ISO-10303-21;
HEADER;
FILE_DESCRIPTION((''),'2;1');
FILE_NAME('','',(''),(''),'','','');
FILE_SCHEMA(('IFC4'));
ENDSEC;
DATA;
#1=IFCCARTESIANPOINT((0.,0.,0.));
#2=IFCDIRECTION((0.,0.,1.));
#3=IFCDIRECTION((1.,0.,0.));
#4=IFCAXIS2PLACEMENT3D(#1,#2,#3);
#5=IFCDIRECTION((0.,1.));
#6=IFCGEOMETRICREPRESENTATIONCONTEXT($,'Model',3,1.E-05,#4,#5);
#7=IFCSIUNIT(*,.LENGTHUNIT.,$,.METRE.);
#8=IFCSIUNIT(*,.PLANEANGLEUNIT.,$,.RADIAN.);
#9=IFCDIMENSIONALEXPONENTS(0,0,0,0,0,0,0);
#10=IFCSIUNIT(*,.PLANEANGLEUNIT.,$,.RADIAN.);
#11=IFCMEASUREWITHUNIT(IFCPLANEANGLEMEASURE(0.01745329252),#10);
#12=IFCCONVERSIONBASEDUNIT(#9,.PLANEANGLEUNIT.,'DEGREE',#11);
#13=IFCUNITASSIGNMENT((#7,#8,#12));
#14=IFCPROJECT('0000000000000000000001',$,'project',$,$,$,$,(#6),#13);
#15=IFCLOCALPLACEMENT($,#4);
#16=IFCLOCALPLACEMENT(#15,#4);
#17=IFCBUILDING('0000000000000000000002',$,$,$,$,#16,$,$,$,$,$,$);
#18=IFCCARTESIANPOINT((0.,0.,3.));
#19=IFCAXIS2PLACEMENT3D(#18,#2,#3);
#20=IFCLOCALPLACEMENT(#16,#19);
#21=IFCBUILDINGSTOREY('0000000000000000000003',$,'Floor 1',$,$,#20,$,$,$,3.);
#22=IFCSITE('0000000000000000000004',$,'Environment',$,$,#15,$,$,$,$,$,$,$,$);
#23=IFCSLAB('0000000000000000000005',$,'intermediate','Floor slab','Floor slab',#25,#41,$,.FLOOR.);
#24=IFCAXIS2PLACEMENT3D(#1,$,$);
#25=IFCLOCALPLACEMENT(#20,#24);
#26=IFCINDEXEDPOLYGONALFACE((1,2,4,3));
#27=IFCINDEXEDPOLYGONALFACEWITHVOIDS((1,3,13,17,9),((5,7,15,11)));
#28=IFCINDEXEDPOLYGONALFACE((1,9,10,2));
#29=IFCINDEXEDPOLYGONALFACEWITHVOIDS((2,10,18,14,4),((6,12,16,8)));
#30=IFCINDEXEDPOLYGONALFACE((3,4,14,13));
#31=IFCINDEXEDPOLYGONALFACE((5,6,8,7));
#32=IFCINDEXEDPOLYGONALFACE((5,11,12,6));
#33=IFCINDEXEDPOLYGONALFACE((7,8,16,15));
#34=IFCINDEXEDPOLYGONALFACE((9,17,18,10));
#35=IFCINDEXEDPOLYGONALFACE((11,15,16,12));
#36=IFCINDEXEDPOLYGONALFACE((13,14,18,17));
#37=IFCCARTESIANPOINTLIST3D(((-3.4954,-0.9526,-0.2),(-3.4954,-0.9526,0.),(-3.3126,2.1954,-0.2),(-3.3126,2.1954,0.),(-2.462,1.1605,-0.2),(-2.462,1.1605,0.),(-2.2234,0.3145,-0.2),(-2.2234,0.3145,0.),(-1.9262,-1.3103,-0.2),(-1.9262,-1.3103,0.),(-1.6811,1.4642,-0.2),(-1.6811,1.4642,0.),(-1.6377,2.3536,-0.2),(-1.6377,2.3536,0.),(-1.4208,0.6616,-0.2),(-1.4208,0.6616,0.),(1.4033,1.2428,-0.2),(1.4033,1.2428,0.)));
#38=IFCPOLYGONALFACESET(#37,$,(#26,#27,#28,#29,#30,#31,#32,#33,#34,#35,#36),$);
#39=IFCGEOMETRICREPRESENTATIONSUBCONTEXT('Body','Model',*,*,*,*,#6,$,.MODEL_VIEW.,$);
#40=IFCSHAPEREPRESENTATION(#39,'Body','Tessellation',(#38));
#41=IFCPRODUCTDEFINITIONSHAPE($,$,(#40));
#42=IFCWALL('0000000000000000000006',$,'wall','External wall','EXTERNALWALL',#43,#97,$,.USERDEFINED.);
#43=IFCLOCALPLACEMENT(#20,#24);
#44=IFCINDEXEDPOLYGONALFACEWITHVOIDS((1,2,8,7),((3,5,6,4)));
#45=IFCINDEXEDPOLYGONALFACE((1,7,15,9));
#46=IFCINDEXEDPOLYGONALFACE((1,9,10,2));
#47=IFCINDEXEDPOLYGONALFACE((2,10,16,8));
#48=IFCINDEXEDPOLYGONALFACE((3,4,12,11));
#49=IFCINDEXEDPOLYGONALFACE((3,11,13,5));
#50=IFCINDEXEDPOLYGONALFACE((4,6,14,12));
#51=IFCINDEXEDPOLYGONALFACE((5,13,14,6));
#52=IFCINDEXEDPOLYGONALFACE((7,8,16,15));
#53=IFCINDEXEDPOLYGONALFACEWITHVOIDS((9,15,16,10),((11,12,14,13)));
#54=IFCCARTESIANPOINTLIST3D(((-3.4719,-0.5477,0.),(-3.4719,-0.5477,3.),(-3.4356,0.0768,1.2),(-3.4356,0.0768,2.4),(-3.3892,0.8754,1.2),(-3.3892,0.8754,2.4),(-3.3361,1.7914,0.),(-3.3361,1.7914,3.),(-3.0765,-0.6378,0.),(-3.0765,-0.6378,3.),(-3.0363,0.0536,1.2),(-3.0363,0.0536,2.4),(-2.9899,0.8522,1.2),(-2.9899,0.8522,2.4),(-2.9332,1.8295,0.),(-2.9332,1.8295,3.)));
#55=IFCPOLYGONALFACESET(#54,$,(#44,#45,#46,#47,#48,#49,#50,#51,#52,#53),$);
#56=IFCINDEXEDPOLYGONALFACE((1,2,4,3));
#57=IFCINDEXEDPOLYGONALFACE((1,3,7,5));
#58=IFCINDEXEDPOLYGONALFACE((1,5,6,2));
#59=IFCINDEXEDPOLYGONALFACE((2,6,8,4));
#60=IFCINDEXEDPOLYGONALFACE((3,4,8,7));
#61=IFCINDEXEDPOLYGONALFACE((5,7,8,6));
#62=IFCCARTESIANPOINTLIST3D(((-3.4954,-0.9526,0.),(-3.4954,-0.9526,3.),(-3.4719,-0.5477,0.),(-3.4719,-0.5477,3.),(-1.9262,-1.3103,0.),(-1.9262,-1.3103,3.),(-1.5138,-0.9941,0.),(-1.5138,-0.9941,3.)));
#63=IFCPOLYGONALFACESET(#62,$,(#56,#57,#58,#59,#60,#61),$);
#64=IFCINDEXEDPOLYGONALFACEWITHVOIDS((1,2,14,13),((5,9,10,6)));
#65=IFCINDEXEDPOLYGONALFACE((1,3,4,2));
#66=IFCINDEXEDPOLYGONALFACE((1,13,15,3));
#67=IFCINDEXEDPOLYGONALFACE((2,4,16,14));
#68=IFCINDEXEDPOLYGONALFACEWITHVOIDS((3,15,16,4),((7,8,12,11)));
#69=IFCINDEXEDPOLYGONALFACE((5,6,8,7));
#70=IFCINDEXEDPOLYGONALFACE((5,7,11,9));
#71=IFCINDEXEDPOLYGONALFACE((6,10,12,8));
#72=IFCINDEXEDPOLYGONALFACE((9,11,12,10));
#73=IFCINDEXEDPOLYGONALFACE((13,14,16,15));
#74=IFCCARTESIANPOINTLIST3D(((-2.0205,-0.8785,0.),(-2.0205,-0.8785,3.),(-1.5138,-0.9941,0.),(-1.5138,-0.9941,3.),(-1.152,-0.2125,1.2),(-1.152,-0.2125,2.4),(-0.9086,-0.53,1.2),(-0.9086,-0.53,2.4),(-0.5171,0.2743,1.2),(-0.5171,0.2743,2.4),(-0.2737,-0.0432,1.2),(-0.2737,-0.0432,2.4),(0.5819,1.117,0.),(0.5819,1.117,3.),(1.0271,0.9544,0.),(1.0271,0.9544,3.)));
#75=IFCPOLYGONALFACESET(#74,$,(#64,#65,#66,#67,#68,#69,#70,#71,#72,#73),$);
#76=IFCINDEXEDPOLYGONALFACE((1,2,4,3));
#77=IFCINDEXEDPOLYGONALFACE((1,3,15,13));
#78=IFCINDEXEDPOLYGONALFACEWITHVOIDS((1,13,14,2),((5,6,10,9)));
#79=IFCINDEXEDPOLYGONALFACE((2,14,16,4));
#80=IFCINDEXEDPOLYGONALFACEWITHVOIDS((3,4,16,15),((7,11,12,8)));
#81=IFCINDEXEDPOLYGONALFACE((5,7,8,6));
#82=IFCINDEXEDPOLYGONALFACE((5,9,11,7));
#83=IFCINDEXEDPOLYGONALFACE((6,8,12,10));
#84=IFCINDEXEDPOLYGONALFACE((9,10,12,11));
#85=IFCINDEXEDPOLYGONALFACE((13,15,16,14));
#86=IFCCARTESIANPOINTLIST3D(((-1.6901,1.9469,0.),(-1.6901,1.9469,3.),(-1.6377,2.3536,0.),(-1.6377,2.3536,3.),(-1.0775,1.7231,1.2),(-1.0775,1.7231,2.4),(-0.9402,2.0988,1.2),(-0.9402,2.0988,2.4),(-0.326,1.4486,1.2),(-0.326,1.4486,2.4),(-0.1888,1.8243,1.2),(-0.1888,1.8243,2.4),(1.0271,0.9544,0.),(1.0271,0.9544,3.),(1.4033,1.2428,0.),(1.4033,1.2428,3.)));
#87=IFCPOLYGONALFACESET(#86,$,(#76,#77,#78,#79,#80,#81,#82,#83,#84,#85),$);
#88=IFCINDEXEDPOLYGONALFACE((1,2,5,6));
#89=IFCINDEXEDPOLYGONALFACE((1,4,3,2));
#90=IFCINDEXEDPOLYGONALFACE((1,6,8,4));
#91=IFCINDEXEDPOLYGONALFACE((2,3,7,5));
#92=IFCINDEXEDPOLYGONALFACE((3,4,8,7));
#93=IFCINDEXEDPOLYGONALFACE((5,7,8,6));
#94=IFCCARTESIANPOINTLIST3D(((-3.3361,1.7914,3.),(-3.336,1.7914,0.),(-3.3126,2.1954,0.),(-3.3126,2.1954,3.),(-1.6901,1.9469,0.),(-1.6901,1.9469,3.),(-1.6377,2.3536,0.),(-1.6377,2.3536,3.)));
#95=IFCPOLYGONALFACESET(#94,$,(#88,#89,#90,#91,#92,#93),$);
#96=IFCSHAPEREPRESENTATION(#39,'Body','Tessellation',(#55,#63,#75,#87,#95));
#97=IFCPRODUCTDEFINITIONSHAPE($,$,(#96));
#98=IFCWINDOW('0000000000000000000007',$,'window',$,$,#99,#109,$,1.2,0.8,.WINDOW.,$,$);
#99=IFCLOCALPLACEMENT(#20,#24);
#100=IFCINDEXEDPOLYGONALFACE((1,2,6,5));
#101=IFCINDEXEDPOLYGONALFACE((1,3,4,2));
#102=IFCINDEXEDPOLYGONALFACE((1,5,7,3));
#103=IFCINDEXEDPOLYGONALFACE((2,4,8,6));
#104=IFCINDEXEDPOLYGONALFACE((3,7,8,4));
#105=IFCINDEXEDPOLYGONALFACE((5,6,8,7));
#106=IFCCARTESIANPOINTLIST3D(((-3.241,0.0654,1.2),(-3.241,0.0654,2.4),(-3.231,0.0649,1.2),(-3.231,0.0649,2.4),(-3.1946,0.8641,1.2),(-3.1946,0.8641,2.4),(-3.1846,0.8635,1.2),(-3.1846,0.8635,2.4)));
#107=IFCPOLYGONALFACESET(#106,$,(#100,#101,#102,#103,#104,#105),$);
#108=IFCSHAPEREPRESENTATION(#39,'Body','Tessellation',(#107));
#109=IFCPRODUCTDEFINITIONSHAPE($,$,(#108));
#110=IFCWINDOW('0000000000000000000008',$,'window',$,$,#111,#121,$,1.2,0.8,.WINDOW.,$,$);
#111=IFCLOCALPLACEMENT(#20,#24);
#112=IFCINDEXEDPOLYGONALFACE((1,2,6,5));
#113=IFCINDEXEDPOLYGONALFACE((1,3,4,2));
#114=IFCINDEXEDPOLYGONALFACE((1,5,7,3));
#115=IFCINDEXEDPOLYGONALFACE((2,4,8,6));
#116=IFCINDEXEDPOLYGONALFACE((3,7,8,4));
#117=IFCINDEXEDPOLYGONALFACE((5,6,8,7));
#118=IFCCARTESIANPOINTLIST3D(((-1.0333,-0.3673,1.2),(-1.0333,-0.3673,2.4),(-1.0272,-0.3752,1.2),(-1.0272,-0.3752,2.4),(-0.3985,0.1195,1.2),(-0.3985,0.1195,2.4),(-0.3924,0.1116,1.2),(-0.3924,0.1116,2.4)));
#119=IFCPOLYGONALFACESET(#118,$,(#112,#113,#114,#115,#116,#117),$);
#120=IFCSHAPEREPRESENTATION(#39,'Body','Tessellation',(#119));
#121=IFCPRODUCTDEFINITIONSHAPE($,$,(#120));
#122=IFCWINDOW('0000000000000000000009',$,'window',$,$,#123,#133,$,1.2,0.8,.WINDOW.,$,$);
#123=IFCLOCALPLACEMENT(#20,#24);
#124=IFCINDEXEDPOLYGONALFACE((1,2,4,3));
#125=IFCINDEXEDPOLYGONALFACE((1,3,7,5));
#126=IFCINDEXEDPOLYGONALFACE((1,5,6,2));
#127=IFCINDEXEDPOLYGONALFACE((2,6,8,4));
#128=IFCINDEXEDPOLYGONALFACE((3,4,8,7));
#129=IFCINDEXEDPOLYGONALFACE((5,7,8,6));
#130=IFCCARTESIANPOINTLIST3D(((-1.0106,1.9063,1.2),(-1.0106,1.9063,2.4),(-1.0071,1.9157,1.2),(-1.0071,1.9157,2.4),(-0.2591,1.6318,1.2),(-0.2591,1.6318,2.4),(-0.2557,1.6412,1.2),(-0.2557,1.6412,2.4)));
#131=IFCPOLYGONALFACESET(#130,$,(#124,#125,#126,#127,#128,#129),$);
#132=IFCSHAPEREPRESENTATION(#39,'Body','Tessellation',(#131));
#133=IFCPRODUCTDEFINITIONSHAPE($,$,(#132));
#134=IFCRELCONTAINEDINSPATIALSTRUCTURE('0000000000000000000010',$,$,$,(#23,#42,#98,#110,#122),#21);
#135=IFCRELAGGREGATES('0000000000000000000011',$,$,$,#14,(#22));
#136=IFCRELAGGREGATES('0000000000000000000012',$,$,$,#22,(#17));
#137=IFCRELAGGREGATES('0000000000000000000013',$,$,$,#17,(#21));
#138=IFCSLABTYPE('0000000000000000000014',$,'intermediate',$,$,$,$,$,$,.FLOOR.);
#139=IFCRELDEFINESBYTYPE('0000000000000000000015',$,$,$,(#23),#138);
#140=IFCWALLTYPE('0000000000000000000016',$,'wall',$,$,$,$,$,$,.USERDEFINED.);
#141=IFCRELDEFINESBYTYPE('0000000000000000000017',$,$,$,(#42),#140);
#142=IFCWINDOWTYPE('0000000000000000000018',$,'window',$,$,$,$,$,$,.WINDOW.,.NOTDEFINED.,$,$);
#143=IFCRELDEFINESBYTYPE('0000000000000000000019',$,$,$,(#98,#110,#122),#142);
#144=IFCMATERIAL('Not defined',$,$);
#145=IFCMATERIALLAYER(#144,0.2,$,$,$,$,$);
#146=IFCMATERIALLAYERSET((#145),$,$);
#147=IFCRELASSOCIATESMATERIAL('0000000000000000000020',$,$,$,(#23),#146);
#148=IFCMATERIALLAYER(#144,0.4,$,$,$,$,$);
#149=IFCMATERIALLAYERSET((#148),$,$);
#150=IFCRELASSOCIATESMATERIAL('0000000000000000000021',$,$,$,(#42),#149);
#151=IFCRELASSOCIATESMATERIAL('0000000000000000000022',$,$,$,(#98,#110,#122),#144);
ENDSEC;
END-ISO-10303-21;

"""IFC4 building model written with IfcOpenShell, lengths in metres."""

from ifc_helpers import new_model, entity, si_unit, converted_unit, direction, frame, origin_with_axes, origin_2d_with_axis, place, context, subcontext, project, spatial, polyline, rectangle, outline, extrude, shape, material, layer, layer_set, layer_usage, type_object, element, fill, save


model = new_model("IFC4")

# Units and contexts
model_context = context("Model", 3, precision=1e-05, world=origin_with_axes(), true_north=direction((0.0, 1.0)))
body_context = subcontext(model_context, "Body", "Model", "MODEL_VIEW")
footprint_context = subcontext(model_context, "FootPrint", "Model", "MODEL_VIEW")
ifc_project = project(units=[si_unit("LENGTHUNIT", "METRE"), si_unit("PLANEANGLEUNIT", "RADIAN"), converted_unit("PLANEANGLEUNIT", "DEGREE", entity("IfcPlaneAngleMeasure", 0.01745329252), si_unit("PLANEANGLEUNIT", "RADIAN"), dimensions=[0, 0, 0, 0, 0, 0, 0])], contexts=[model_context])

# Site, building, storey
site_placement = place(None, origin_with_axes())
site = spatial("IfcSite", under=ifc_project, at=site_placement, Name="Environment")
building_placement = place(site_placement, origin_with_axes())
building = spatial("IfcBuilding", under=site, at=building_placement)
storey_placement = place(building_placement, frame((0.0, 0.0, 3.0), z_axis=(0.0, 0.0, 1.0), x_axis=(1.0, 0.0, 0.0)))
storey = spatial("IfcBuildingStorey", under=building, at=storey_placement, Name="Floor 1", Elevation=3.0)

# Slab, opening
ifc_material = material(Name="Not defined")
ifc_layer_1 = layer(ifc_material, 0.2)
ifc_layer_set_1 = layer_set([ifc_layer_1])
ifc_layer_usage_1 = layer_usage(ifc_layer_set_1, "AXIS3", "POSITIVE", 0.0)
slab_type = type_object("IfcSlabType", Name="intermediate", PredefinedType="FLOOR")
slab_placement = place(storey_placement, frame((-3.3126, 2.1954, -0.2), z_axis=(0.0, 0.0, 1.0), x_axis=(1.0, 0.0, 0.0)))
slab = element("IfcSlab", 1, at=slab_placement, inside=storey, type_object=slab_type, material=ifc_layer_usage_1, Name="intermediate", Description="Floor slab", ObjectType="Floor slab", PredefinedType="FLOOR", context=body_context, shape_type="SweptSolid", body=[
    extrude(outline(polyline([(0.0, 0.0), (-0.1828, -3.148), (1.3864, -3.5057), (4.7159, -0.9526), (1.6748, 0.1582), (0.0, 0.0)])), origin_with_axes(), (0.0, 0.0, 1.0), 0.2),
])
opening_1_placement = place(slab_placement, frame((1.0891, -1.8809, -0.01), z_axis=(0.0, 0.0, 1.0), x_axis=(1.0, 0.0, 0.0)))
element("IfcOpeningElement", 2, at=opening_1_placement, cuts=slab, ObjectType="Not defined", PredefinedType="OPENING", context=body_context, shape_type="SweptSolid", body=[
    extrude(outline(polyline([(-0.2386, 0.846), (0.0, 0.0), (0.8026, 0.3471), (0.5423, 1.1497), (-0.2386, 0.846)])), origin_with_axes(), (0.0, 0.0, 1.0), 0.22),
])

# Wall, openings, windows
ifc_layer_2 = layer(ifc_material, 0.4)
ifc_layer_set_2 = layer_set([ifc_layer_2])
ifc_layer_usage_2 = layer_usage(ifc_layer_set_2, "AXIS2", "POSITIVE", 0.0)
wall_type = type_object("IfcWallType", Name="wall", PredefinedType="USERDEFINED")
wall_placement = place(storey_placement, frame((-3.3126, 2.1954, 0.0), z_axis=(0.0, 0.0, 1.0), x_axis=(-0.057974, -0.998318, 0.0)))
cartesian_point_1 = entity("IfcCartesianPoint", [-1.2357, -1.5])
cartesian_point_2 = entity("IfcCartesianPoint", [-1.1715, -1.5])
cartesian_point_3 = entity("IfcCartesianPoint", [-1.0042, -1.5])
cartesian_point_4 = entity("IfcCartesianPoint", [-0.8047, -1.5])
cartesian_point_5 = entity("IfcCartesianPoint", [-1.6397, -1.5])
cartesian_point_6 = entity("IfcCartesianPoint", [-1.601, -1.5])
cartesian_point_7 = entity("IfcCartesianPoint", [-1.4464, -1.5])
cartesian_point_8 = entity("IfcCartesianPoint", [-1.6188, -1.5])
cartesian_point_9 = entity("IfcCartesianPoint", [-0.8267, -1.5])
cartesian_point_10 = entity("IfcCartesianPoint", [-0.8412, -1.5])
wall = element("IfcWall", 3, at=wall_placement, inside=storey, type_object=wall_type, material=ifc_layer_usage_2, Name="wall", Description="External wall", ObjectType="EXTERNALWALL", PredefinedType="USERDEFINED", context=body_context, shape_type="SolidModel", body=[
    entity("IfcExtrudedAreaSolidTapered", entity("IfcArbitraryClosedProfileDef", "AREA", None, entity("IfcPolyline", [cartesian_point_1, entity("IfcCartesianPoint", [1.2357, -1.5]), entity("IfcCartesianPoint", [1.2357, 1.5]), entity("IfcCartesianPoint", [-1.2357, 1.5]), cartesian_point_1])), entity("IfcAxis2Placement3D", entity("IfcCartesianPoint", [1.5791, 0.4, 1.5]), entity("IfcDirection", [0.0, -1.0, 0.0]), entity("IfcDirection", [1.0, 0.0, 0.0])), entity("IfcDirection", [-0.00715, 0.0, 0.999974]), 0.4, entity("IfcArbitraryClosedProfileDef", "AREA", None, entity("IfcPolyline", [cartesian_point_2, entity("IfcCartesianPoint", [1.1715, -1.5]), entity("IfcCartesianPoint", [1.1715, 1.5]), entity("IfcCartesianPoint", [-1.1715, 1.5]), cartesian_point_2]))),
    entity("IfcExtrudedAreaSolidTapered", entity("IfcArbitraryClosedProfileDef", "AREA", None, entity("IfcPolyline", [cartesian_point_3, entity("IfcCartesianPoint", [1.0042, -1.5]), entity("IfcCartesianPoint", [1.0042, 1.5]), entity("IfcCartesianPoint", [-1.0042, 1.5]), cartesian_point_3])), entity("IfcAxis2Placement3D", entity("IfcCartesianPoint", [2.9138, 0.9903, 1.5]), entity("IfcDirection", [0.986235, -0.165351, 0.0]), entity("IfcDirection", [0.165351, 0.986235, 0.0])), entity("IfcDirection", [-0.314185, 0.0, 0.949362]), 0.4213, entity("IfcArbitraryClosedProfileDef", "AREA", None, entity("IfcPolyline", [cartesian_point_4, entity("IfcCartesianPoint", [0.8047, -1.5]), entity("IfcCartesianPoint", [0.8047, 1.5]), entity("IfcCartesianPoint", [-0.8047, 1.5]), cartesian_point_4]))),
    entity("IfcExtrudedAreaSolidTapered", entity("IfcArbitraryClosedProfileDef", "AREA", None, entity("IfcPolyline", [cartesian_point_5, entity("IfcCartesianPoint", [1.6397, -1.5]), entity("IfcCartesianPoint", [1.6397, 1.5]), entity("IfcCartesianPoint", [-1.6397, 1.5]), cartesian_point_5])), entity("IfcAxis2Placement3D", entity("IfcCartesianPoint", [1.9223, 2.7093, 1.5]), entity("IfcDirection", [0.756938, 0.653486, 0.0]), entity("IfcDirection", [-0.653486, 0.756938, 0.0])), entity("IfcDirection", [0.591047, 0.0, 0.806637]), 0.4959, entity("IfcArbitraryClosedProfileDef", "AREA", None, entity("IfcPolyline", [cartesian_point_6, entity("IfcCartesianPoint", [1.601, -1.5]), entity("IfcCartesianPoint", [1.601, 1.5]), entity("IfcCartesianPoint", [-1.601, 1.5]), cartesian_point_6]))),
    entity("IfcExtrudedAreaSolidTapered", entity("IfcArbitraryClosedProfileDef", "AREA", None, entity("IfcPolyline", [cartesian_point_7, entity("IfcCartesianPoint", [1.4464, -1.5]), entity("IfcCartesianPoint", [1.4464, 1.5]), entity("IfcCartesianPoint", [-1.4464, 1.5]), cartesian_point_7])), entity("IfcAxis2Placement3D", entity("IfcCartesianPoint", [0.5707, 3.0193, 1.5]), entity("IfcDirection", [-0.957609, 0.28807, 0.0]), entity("IfcDirection", [-0.28807, -0.957609, 0.0])), entity("IfcDirection", [-0.200815, 0.0, 0.979629]), 0.4083, entity("IfcArbitraryClosedProfileDef", "AREA", None, entity("IfcPolyline", [cartesian_point_8, entity("IfcCartesianPoint", [1.6188, -1.5]), entity("IfcCartesianPoint", [1.6188, 1.5]), entity("IfcCartesianPoint", [-1.6188, 1.5]), cartesian_point_8]))),
    entity("IfcExtrudedAreaSolidTapered", entity("IfcArbitraryClosedProfileDef", "AREA", None, entity("IfcPolyline", [cartesian_point_9, entity("IfcCartesianPoint", [0.8266, -1.5]), entity("IfcCartesianPoint", [0.8267, 1.5]), entity("IfcCartesianPoint", [-0.8267, 1.5]), cartesian_point_9])), entity("IfcAxis2Placement3D", entity("IfcCartesianPoint", [0.2794, 0.8171, 1.5]), entity("IfcDirection", [-0.988443, -0.151594, 0.0]), entity("IfcDirection", [0.151594, -0.988443, 0.0])), entity("IfcDirection", [-0.186324, 0.0, 0.982488]), 0.4071, entity("IfcArbitraryClosedProfileDef", "AREA", None, entity("IfcPolyline", [cartesian_point_10, entity("IfcCartesianPoint", [0.8412, -1.5]), entity("IfcCartesianPoint", [0.8412, 1.5]), entity("IfcCartesianPoint", [-0.8412, 1.5]), cartesian_point_10]))),
])
opening_2_placement = place(wall_placement, frame((1.7222, 0.2, 1.8), z_axis=(0.0, 0.0, 1.0), x_axis=(1.0, 0.0, 0.0)))
cartesian_point_11 = entity("IfcCartesianPoint", [-0.4, -0.2])
opening_2 = element("IfcOpeningElement", 4, at=opening_2_placement, cuts=wall, ObjectType="Not defined", PredefinedType="OPENING", shapes=[
    shape(body_context, "Body", "SweptSolid", [extrude(rectangle(XDim=1.2, YDim=0.8, at=origin_2d_with_axis()), frame((0.0, -0.2, 0.0), z_axis=(0.0, 1.0, 0.0), x_axis=(0.0, 0.0, 1.0)), (0.0, 0.0, 1.0), 0.4)]),
    shape(footprint_context, "FootPrint", "GeometricCurveSet", [entity("IfcGeometricCurveSet", [entity("IfcPolyline", [cartesian_point_11, entity("IfcCartesianPoint", [0.4, -0.2]), entity("IfcCartesianPoint", [0.4, 0.2]), entity("IfcCartesianPoint", [-0.4, 0.2]), cartesian_point_11])])]),
])
opening_3_placement = place(wall_placement, frame((2.1686, 2.73, 1.8), z_axis=(0.0, 0.0, 1.0), x_axis=(-0.653486, 0.756938, 0.0)))
cartesian_point_12 = entity("IfcCartesianPoint", [-0.4, -0.2])
opening_3 = element("IfcOpeningElement", 5, at=opening_3_placement, cuts=wall, ObjectType="Not defined", PredefinedType="OPENING", shapes=[
    shape(body_context, "Body", "SweptSolid", [extrude(rectangle(XDim=1.2, YDim=0.8, at=origin_2d_with_axis()), frame((0.0, -0.2, 0.0), z_axis=(0.0, 1.0, 0.0), x_axis=(0.0, 0.0, 1.0)), (0.0, 0.0, 1.0), 0.4)]),
    shape(footprint_context, "FootPrint", "GeometricCurveSet", [entity("IfcGeometricCurveSet", [entity("IfcPolyline", [cartesian_point_12, entity("IfcCartesianPoint", [0.4, -0.2]), entity("IfcCartesianPoint", [0.4, 0.2]), entity("IfcCartesianPoint", [-0.4, 0.2]), cartesian_point_12])])]),
])
opening_4_placement = place(wall_placement, frame((0.2656, 2.6994, 1.8), z_axis=(0.0, 0.0, 1.0), x_axis=(-0.28807, -0.957609, 0.0)))
cartesian_point_13 = entity("IfcCartesianPoint", [-0.4, -0.2])
opening_4 = element("IfcOpeningElement", 6, at=opening_4_placement, cuts=wall, ObjectType="Not defined", PredefinedType="OPENING", shapes=[
    shape(body_context, "Body", "SweptSolid", [extrude(rectangle(XDim=1.2, YDim=0.8, at=origin_2d_with_axis()), frame((0.0, -0.2, 0.0), z_axis=(0.0, 1.0, 0.0), x_axis=(0.0, 0.0, 1.0)), (0.0, 0.0, 1.0), 0.4)]),
    shape(footprint_context, "FootPrint", "GeometricCurveSet", [entity("IfcGeometricCurveSet", [entity("IfcPolyline", [cartesian_point_13, entity("IfcCartesianPoint", [0.4, -0.2]), entity("IfcCartesianPoint", [0.4, 0.2]), entity("IfcCartesianPoint", [-0.4, 0.2]), cartesian_point_13])])]),
])
window_type = type_object("IfcWindowType", Name="window", PartitioningType="NOTDEFINED", PredefinedType="WINDOW")
window_1_placement = place(opening_2_placement, origin_with_axes())
window_1 = element("IfcWindow", 7, at=window_1_placement, inside=storey, type_object=window_type, material=ifc_material, Name="window", OverallHeight=1.2, OverallWidth=0.8, PredefinedType="WINDOW", context=body_context, shape_type="SweptSolid", body=[
    extrude(rectangle(XDim=0.8, YDim=1.2, at=origin_2d_with_axis()), frame((0.0, 0.005, 0.0), z_axis=(0.0, -1.0, 0.0), x_axis=(1.0, 0.0, 0.0)), (0.0, 0.0, 1.0), 0.01),
])
fill(opening_2, window_1)
window_2_placement = place(opening_3_placement, origin_with_axes())
window_2 = element("IfcWindow", 8, at=window_2_placement, inside=storey, type_object=window_type, material=ifc_material, Name="window", OverallHeight=1.2, OverallWidth=0.8, PredefinedType="WINDOW", context=body_context, shape_type="SweptSolid", body=[
    extrude(rectangle(XDim=0.8, YDim=1.2, at=origin_2d_with_axis()), frame((0.0, 0.005, 0.0), z_axis=(0.0, -1.0, 0.0), x_axis=(1.0, 0.0, 0.0)), (0.0, 0.0, 1.0), 0.01),
])
fill(opening_3, window_2)
window_3_placement = place(opening_4_placement, origin_with_axes())
window_3 = element("IfcWindow", 9, at=window_3_placement, inside=storey, type_object=window_type, material=ifc_material, Name="window", OverallHeight=1.2, OverallWidth=0.8, PredefinedType="WINDOW", context=body_context, shape_type="SweptSolid", body=[
    extrude(rectangle(XDim=0.8, YDim=1.2, at=origin_2d_with_axis()), frame((0.0, 0.005, 0.0), z_axis=(0.0, -1.0, 0.0), x_axis=(1.0, 0.0, 0.0)), (0.0, 0.0, 1.0), 0.01),
])
fill(opening_4, window_3)

save(model, "model.ifc")
